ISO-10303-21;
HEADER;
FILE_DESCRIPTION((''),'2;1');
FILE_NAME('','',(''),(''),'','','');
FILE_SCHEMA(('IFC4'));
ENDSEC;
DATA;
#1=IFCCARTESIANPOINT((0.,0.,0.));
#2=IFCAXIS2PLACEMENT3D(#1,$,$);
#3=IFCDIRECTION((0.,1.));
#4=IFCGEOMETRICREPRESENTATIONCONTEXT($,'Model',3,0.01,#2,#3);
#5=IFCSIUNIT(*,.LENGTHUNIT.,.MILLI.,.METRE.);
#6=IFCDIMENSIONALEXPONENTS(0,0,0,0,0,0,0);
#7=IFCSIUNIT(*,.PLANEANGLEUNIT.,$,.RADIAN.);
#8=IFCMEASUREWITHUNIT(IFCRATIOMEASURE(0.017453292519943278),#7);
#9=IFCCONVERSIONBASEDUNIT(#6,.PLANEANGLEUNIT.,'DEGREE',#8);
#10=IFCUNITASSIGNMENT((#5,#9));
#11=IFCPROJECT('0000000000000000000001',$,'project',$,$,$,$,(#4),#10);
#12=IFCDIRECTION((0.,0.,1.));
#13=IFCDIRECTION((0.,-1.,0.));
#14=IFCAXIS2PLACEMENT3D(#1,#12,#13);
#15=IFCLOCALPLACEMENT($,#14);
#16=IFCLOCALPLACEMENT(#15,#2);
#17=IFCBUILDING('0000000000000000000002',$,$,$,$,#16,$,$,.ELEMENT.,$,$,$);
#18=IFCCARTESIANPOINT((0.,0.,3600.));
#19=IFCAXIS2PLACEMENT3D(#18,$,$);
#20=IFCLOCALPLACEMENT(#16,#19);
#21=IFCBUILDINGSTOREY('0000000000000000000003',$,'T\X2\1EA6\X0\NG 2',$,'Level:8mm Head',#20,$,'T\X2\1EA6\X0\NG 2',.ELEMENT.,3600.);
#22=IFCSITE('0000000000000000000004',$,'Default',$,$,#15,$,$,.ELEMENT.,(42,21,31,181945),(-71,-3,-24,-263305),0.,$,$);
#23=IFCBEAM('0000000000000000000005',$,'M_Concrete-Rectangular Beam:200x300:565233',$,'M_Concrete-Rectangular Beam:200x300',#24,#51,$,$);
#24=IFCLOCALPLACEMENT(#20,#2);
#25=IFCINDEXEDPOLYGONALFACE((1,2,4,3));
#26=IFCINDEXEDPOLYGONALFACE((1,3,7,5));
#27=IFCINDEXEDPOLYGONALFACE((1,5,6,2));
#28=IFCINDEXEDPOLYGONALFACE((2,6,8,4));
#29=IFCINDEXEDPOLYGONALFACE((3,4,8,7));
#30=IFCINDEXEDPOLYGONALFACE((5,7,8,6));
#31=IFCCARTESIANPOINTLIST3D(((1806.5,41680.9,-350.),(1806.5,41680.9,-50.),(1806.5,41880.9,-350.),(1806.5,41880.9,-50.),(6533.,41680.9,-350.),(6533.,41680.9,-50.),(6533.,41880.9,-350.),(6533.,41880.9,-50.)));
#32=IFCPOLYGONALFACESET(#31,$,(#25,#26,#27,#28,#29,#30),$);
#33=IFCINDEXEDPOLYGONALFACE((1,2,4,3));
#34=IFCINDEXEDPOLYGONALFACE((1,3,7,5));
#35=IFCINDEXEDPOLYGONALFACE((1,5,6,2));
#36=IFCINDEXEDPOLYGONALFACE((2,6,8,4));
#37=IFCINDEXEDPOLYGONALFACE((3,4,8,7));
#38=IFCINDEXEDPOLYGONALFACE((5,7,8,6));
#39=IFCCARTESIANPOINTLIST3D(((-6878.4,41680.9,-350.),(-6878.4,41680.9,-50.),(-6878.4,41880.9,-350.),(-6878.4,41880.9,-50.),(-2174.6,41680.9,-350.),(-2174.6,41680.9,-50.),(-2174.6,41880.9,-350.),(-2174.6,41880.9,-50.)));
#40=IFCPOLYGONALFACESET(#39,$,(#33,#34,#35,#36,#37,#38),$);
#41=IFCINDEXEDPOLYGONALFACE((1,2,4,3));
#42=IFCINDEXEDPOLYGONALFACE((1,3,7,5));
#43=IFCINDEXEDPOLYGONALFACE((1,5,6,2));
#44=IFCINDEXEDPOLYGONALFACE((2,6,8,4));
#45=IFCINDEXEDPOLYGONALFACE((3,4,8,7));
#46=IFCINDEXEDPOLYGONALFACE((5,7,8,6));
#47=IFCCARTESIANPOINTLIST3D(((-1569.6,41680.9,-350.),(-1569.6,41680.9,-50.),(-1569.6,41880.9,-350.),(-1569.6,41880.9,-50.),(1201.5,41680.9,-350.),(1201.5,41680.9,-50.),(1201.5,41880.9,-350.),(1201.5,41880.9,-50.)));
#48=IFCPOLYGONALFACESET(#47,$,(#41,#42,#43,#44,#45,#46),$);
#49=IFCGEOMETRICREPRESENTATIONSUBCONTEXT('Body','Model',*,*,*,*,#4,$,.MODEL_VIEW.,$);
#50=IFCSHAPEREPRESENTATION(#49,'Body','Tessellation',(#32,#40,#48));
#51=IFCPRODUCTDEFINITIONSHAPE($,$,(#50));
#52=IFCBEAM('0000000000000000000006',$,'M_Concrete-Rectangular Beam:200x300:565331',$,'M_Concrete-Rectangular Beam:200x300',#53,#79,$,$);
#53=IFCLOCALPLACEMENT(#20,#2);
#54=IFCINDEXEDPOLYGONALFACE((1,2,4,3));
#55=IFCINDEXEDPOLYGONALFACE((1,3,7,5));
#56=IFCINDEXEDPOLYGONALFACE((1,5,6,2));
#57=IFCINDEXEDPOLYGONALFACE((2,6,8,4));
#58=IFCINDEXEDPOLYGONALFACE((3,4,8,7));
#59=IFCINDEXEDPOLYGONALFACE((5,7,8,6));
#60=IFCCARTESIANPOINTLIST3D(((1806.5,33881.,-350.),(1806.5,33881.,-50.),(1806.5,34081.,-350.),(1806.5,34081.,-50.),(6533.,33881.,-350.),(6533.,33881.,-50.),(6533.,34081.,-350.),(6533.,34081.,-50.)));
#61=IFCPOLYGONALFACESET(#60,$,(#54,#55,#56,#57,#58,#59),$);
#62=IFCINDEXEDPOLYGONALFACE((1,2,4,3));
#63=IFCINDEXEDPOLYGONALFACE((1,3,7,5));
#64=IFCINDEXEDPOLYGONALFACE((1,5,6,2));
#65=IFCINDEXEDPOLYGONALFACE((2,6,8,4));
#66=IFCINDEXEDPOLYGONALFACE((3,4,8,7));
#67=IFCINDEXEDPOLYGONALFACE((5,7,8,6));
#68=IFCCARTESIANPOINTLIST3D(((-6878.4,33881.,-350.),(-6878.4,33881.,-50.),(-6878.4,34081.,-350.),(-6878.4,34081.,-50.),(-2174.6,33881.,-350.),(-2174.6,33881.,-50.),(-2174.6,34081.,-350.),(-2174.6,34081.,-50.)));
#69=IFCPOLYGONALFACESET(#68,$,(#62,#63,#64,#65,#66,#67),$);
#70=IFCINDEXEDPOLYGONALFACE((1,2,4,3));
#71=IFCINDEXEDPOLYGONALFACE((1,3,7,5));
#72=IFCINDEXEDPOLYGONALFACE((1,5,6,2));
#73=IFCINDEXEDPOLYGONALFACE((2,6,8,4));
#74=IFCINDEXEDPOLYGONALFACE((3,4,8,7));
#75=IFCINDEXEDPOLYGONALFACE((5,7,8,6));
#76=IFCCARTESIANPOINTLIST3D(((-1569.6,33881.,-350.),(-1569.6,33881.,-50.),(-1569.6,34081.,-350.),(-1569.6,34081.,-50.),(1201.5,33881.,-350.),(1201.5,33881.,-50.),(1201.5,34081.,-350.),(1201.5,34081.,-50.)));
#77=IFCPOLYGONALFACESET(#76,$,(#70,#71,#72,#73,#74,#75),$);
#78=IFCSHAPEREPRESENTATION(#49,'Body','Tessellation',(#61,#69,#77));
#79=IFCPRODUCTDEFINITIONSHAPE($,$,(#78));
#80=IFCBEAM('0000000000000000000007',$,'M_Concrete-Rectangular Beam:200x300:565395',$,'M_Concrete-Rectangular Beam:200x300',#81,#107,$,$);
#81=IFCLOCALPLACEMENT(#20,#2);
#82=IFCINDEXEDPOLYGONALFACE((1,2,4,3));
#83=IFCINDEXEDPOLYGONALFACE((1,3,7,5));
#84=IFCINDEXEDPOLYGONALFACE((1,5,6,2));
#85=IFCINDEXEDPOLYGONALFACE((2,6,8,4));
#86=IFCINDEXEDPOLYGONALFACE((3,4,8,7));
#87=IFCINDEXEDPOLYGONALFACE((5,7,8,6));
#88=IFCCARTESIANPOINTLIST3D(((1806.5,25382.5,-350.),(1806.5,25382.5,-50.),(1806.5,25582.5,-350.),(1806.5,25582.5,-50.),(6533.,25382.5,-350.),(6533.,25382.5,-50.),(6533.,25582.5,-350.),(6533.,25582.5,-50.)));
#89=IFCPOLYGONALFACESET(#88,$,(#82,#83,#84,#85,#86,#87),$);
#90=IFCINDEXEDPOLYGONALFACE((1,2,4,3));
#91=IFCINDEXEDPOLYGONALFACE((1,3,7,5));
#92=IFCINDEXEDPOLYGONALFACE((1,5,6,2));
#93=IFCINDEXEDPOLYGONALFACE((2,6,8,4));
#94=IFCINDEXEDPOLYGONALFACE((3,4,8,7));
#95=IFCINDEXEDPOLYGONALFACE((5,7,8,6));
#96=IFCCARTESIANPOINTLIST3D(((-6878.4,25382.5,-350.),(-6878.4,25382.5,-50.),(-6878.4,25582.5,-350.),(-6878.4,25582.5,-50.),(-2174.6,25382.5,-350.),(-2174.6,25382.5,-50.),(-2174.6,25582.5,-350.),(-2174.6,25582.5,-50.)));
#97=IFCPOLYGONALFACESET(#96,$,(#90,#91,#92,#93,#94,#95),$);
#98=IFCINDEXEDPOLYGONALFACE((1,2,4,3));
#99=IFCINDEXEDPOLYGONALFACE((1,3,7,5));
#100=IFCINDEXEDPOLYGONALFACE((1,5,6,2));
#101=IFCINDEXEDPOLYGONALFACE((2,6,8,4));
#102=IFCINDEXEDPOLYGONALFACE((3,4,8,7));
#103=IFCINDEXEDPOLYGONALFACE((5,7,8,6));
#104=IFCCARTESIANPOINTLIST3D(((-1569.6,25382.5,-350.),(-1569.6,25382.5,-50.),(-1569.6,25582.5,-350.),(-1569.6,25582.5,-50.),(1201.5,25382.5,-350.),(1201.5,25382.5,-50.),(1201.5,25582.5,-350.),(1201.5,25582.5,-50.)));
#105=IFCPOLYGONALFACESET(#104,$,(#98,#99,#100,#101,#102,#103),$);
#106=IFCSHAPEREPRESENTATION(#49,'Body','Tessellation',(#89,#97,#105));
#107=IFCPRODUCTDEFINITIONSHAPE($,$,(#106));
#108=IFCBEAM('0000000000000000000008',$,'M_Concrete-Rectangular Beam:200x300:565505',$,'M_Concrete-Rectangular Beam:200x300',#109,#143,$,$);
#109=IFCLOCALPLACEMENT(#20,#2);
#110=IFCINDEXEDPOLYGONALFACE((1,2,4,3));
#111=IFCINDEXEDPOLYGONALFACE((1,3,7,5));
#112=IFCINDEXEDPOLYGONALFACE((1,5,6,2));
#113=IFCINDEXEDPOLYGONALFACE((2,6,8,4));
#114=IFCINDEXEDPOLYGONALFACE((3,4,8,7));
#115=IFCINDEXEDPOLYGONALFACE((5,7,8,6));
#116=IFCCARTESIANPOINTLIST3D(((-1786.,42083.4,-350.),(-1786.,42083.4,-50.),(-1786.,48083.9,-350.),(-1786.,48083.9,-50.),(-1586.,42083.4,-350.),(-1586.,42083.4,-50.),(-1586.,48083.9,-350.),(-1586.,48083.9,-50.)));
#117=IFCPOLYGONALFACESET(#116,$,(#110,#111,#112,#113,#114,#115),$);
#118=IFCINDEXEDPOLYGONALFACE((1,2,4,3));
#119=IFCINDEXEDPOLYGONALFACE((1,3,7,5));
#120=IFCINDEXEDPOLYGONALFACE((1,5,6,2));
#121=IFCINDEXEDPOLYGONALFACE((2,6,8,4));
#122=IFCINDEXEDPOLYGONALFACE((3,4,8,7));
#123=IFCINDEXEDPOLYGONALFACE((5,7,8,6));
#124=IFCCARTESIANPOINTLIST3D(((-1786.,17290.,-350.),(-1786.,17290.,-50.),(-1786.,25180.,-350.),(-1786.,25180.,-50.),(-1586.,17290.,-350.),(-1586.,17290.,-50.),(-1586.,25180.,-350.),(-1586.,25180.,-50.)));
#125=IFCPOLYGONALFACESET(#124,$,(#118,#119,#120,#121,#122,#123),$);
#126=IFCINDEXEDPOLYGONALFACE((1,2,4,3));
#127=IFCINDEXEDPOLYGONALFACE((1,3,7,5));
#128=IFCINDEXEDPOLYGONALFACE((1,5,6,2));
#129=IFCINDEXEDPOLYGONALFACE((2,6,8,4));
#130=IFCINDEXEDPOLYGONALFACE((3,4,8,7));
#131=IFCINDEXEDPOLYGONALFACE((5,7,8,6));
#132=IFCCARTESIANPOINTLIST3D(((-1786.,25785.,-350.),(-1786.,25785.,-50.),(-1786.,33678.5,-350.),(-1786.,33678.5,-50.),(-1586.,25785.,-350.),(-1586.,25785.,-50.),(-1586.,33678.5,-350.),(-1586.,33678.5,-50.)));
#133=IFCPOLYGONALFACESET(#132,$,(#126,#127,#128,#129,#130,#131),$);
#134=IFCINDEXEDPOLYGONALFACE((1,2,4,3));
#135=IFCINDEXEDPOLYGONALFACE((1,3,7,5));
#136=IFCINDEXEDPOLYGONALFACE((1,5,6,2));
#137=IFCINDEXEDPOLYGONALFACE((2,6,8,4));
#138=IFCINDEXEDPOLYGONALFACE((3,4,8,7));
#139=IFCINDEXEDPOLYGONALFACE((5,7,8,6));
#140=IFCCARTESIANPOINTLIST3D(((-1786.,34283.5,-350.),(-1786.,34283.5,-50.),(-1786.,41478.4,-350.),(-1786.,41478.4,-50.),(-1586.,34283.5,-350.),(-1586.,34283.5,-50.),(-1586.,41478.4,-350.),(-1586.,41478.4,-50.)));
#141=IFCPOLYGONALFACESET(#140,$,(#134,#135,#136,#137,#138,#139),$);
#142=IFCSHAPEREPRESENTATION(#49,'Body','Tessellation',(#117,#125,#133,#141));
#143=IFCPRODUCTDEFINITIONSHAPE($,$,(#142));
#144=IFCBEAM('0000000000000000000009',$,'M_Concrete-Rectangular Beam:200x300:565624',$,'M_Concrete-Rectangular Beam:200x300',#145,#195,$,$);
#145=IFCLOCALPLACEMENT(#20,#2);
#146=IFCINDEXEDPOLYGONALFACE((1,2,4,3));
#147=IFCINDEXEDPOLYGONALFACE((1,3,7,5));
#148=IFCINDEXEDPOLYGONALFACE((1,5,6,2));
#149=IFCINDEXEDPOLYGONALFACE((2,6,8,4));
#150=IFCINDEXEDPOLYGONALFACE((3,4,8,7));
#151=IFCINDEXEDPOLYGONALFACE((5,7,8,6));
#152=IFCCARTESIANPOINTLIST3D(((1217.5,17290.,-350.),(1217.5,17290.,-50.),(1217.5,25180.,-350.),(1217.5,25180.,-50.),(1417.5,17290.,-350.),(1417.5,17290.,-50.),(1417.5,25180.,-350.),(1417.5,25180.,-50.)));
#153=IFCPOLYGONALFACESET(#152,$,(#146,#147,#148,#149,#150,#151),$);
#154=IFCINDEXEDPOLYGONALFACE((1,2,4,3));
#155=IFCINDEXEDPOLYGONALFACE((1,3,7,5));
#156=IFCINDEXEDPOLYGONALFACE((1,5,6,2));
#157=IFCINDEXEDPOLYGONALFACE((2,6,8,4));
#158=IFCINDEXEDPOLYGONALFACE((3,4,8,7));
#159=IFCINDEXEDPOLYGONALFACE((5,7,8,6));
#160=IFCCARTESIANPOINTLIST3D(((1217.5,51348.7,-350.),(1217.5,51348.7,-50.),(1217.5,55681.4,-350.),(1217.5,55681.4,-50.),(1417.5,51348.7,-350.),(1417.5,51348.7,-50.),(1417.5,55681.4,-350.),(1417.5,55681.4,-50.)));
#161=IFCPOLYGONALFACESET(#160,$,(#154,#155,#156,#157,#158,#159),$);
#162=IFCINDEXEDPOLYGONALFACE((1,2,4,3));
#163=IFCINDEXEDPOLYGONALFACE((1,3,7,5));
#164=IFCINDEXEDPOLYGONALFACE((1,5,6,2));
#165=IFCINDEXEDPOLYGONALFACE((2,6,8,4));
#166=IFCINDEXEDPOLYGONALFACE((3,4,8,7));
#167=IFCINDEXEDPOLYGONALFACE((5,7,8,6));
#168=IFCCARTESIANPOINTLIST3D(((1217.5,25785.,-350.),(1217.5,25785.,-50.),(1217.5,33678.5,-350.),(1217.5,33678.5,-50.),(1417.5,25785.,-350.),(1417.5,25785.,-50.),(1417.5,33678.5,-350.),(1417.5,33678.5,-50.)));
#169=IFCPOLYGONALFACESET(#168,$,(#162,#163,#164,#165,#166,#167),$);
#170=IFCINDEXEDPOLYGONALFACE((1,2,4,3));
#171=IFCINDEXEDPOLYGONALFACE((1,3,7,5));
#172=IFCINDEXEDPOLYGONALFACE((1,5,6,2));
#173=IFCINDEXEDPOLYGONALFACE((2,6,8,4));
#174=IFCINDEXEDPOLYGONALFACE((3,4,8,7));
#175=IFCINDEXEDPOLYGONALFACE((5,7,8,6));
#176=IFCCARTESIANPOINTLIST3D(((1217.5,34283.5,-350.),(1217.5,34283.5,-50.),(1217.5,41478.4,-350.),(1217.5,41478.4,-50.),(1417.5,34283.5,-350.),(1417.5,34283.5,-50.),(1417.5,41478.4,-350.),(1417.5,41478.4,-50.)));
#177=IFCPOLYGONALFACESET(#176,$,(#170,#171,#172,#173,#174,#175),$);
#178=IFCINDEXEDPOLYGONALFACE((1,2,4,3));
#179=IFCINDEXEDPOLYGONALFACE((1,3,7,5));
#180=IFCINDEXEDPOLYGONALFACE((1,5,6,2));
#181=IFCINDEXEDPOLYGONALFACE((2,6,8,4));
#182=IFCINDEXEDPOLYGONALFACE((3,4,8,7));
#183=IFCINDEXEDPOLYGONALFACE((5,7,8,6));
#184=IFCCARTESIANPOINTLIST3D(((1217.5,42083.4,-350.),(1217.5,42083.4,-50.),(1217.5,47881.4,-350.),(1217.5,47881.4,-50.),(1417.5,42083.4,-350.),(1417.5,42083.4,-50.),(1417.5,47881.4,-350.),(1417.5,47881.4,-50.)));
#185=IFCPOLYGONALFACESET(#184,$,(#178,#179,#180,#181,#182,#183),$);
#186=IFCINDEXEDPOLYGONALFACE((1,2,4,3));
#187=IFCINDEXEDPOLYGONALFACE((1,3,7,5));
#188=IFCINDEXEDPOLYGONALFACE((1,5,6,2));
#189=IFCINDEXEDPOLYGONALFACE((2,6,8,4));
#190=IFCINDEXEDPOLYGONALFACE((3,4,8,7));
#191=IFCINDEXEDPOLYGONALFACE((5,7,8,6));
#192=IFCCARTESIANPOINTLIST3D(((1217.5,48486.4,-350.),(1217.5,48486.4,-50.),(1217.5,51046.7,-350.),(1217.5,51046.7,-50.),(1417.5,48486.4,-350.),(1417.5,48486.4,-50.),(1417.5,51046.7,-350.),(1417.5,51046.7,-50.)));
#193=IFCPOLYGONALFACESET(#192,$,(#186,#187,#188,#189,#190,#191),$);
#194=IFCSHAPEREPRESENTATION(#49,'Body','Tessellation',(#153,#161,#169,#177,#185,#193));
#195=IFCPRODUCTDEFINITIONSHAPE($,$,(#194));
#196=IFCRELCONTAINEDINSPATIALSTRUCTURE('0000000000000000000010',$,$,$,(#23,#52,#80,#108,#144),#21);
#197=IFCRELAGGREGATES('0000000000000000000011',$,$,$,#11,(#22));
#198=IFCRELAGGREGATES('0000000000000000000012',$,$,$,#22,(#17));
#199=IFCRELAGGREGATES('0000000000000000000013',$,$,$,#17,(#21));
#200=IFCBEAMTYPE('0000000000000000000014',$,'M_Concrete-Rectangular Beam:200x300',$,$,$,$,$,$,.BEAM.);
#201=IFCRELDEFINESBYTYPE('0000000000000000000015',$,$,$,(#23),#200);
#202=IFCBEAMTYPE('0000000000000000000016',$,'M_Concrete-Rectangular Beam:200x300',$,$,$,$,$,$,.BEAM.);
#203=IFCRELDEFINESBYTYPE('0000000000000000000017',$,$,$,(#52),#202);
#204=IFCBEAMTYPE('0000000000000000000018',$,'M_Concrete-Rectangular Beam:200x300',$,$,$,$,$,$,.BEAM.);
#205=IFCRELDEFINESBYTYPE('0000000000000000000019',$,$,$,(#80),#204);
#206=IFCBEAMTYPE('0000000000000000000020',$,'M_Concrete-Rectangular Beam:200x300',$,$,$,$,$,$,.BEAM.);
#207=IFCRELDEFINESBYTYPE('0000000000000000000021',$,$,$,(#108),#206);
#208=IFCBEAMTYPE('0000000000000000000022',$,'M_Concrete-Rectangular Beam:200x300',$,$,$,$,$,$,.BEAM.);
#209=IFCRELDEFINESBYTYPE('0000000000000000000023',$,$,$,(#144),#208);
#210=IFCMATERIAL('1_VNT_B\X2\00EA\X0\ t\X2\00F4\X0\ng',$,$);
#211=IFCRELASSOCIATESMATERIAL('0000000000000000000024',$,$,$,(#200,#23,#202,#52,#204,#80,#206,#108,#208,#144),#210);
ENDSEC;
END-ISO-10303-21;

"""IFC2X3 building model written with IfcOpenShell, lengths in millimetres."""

from ifc_helpers import new_model, entity, si_unit, converted_unit, direction, frame, frame_2d, origin, origin_2d_with_axis, place, context, subcontext, project, spatial, rectangle, extrude, source, transform, mapped, material, type_object, type_shapes, element, save


model = new_model("IFC2X3")

# Units and contexts
model_context = context("Model", 3, precision=0.01, world=origin(), true_north=direction((0.0, 1.0)))
body_context = subcontext(model_context, "Body", "Model", "MODEL_VIEW")
ifc_project = project(units=[si_unit("LENGTHUNIT", "METRE", prefix="MILLI"), converted_unit("PLANEANGLEUNIT", "DEGREE", entity("IfcRatioMeasure", 0.017453292519943278), si_unit("PLANEANGLEUNIT", "RADIAN"), dimensions=[0, 0, 0, 0, 0, 0, 0])], contexts=[model_context])

# Site, building, storey
site_placement = place(None, frame((0.0, 0.0, 0.0), z_axis=(0.0, 0.0, 1.0), x_axis=(0.0, -1.0, 0.0)))
site = spatial("IfcSite", under=ifc_project, at=site_placement, Name="Default", CompositionType="ELEMENT", RefLatitude=(42, 21, 31, 181945), RefLongitude=(-71, -3, -24, -263305), RefElevation=0.0)
building_placement = place(site_placement, origin())
building = spatial("IfcBuilding", under=site, at=building_placement, CompositionType="ELEMENT")
storey_placement = place(building_placement, frame((0.0, 0.0, 3600.0)))
storey = spatial("IfcBuildingStorey", under=building, at=storey_placement, Name="TẦNG 2", ObjectType="Level:8mm Head", LongName="TẦNG 2", CompositionType="ELEMENT", Elevation=3600.0)

# Beams
ifc_material = material(Name="1_VNT_Bê tông")
beam_type_1 = type_object("IfcBeamType", Name="M_Concrete-Rectangular Beam:200x300", PredefinedType="BEAM", material=ifc_material)
shared_shape_1 = source(origin(), body_context, "Body", "SweptSolid", [
    extrude(rectangle(XDim=300.0, YDim=200.0, at=origin_2d_with_axis()), frame((1806.5, 41780.9, 3400.0), z_axis=(1.0, 0.0, 0.0), x_axis=(0.0, 0.0, -1.0)), (0.0, 0.0, 1.0), 4726.6),
    extrude(rectangle(XDim=300.0, YDim=200.0, at=origin_2d_with_axis()), frame((-6878.4, 41780.9, 3400.0), z_axis=(1.0, 0.0, 0.0), x_axis=(0.0, 0.0, -1.0)), (0.0, 0.0, 1.0), 4703.8),
    extrude(rectangle(XDim=300.0, YDim=200.0, at=origin_2d_with_axis()), frame((-1569.6, 41780.9, 3400.0), z_axis=(1.0, 0.0, 0.0), x_axis=(0.0, 0.0, -1.0)), (0.0, 0.0, 1.0), 2771.1),
])
type_shapes(beam_type_1, [shared_shape_1])
beam_1_placement = place(storey_placement, frame((0.0, 0.0, -3600.0)))
element("IfcBeam", 1, at=beam_1_placement, inside=storey, type_object=beam_type_1, material=ifc_material, Name="M_Concrete-Rectangular Beam:200x300:565233", ObjectType="M_Concrete-Rectangular Beam:200x300", context=body_context, shape_type="MappedRepresentation", body=[
    mapped(shared_shape_1, transform((0.0, 0.0, 0.0), scale=1.0)),
])
beam_type_2 = type_object("IfcBeamType", Name="M_Concrete-Rectangular Beam:200x300", PredefinedType="BEAM", material=ifc_material)
shared_shape_2 = source(origin(), body_context, "Body", "SweptSolid", [
    extrude(rectangle(XDim=300.0, YDim=200.0, at=frame_2d((0.0, 0.0), x_axis=(1.0, 0.0))), frame((1806.5, 33981.0, 3400.0), z_axis=(1.0, 0.0, 0.0), x_axis=(0.0, 0.0, -1.0)), (0.0, 0.0, 1.0), 4726.6),
    extrude(rectangle(XDim=300.0, YDim=200.0, at=origin_2d_with_axis()), frame((-6878.4, 33981.0, 3400.0), z_axis=(1.0, 0.0, 0.0), x_axis=(0.0, 0.0, -1.0)), (0.0, 0.0, 1.0), 4703.8),
    extrude(rectangle(XDim=300.0, YDim=200.0, at=frame_2d((0.0, 0.0), x_axis=(1.0, 0.0))), frame((-1569.6, 33981.0, 3400.0), z_axis=(1.0, 0.0, 0.0), x_axis=(0.0, 0.0, -1.0)), (0.0, 0.0, 1.0), 2771.1),
])
type_shapes(beam_type_2, [shared_shape_2])
beam_2_placement = place(storey_placement, frame((0.0, 0.0, -3600.0)))
element("IfcBeam", 2, at=beam_2_placement, inside=storey, type_object=beam_type_2, material=ifc_material, Name="M_Concrete-Rectangular Beam:200x300:565331", ObjectType="M_Concrete-Rectangular Beam:200x300", context=body_context, shape_type="MappedRepresentation", body=[
    mapped(shared_shape_2, transform((0.0, 0.0, 0.0), scale=1.0)),
])
beam_type_3 = type_object("IfcBeamType", Name="M_Concrete-Rectangular Beam:200x300", PredefinedType="BEAM", material=ifc_material)
shared_shape_3 = source(origin(), body_context, "Body", "SweptSolid", [
    extrude(rectangle(XDim=300.0, YDim=200.0, at=frame_2d((0.0, 0.0), x_axis=(1.0, 0.0))), frame((1806.5, 25482.5, 3400.0), z_axis=(1.0, 0.0, 0.0), x_axis=(0.0, 0.0, -1.0)), (0.0, 0.0, 1.0), 4726.6),
    extrude(rectangle(XDim=300.0, YDim=200.0, at=frame_2d((0.0, 0.0), x_axis=(1.0, 0.0))), frame((-6878.4, 25482.5, 3400.0), z_axis=(1.0, 0.0, 0.0), x_axis=(0.0, 0.0, -1.0)), (0.0, 0.0, 1.0), 4703.8),
    extrude(rectangle(XDim=300.0, YDim=200.0, at=frame_2d((0.0, 0.0), x_axis=(1.0, 0.0))), frame((-1569.6, 25482.5, 3400.0), z_axis=(1.0, 0.0, 0.0), x_axis=(0.0, 0.0, -1.0)), (0.0, 0.0, 1.0), 2771.1),
])
type_shapes(beam_type_3, [shared_shape_3])
beam_3_placement = place(storey_placement, frame((0.0, 0.0, -3600.0)))
element("IfcBeam", 3, at=beam_3_placement, inside=storey, type_object=beam_type_3, material=ifc_material, Name="M_Concrete-Rectangular Beam:200x300:565395", ObjectType="M_Concrete-Rectangular Beam:200x300", context=body_context, shape_type="MappedRepresentation", body=[
    mapped(shared_shape_3, transform((0.0, 0.0, 0.0), scale=1.0)),
])
beam_type_4 = type_object("IfcBeamType", Name="M_Concrete-Rectangular Beam:200x300", PredefinedType="BEAM", material=ifc_material)
shared_shape_4 = source(origin(), body_context, "Body", "SweptSolid", [
    extrude(rectangle(XDim=300.0, YDim=200.0, at=frame_2d((0.0, 0.0), x_axis=(0.0, 1.0))), frame((-1686.0, 42083.4, 3400.0), z_axis=(0.0, 1.0, 0.0), x_axis=(-1.0, 0.0, 0.0)), (0.0, 0.0, 1.0), 6000.5),
    extrude(rectangle(XDim=300.0, YDim=200.0, at=frame_2d((0.0, 0.0), x_axis=(0.0, 1.0))), frame((-1686.0, 17290.0, 3400.0), z_axis=(0.0, 1.0, 0.0), x_axis=(-1.0, 0.0, 0.0)), (0.0, 0.0, 1.0), 7890.0),
    extrude(rectangle(XDim=300.0, YDim=200.0, at=frame_2d((0.0, 0.0), x_axis=(0.0, 1.0))), frame((-1686.0, 25785.0, 3400.0), z_axis=(0.0, 1.0, 0.0), x_axis=(-1.0, 0.0, 0.0)), (0.0, 0.0, 1.0), 7893.5),
    extrude(rectangle(XDim=300.0, YDim=200.0, at=frame_2d((0.0, 0.0), x_axis=(0.0, 1.0))), frame((-1686.0, 34283.5, 3400.0), z_axis=(0.0, 1.0, 0.0), x_axis=(-1.0, 0.0, 0.0)), (0.0, 0.0, 1.0), 7195.0),
])
type_shapes(beam_type_4, [shared_shape_4])
beam_4_placement = place(storey_placement, frame((0.0, 0.0, -3600.0)))
element("IfcBeam", 4, at=beam_4_placement, inside=storey, type_object=beam_type_4, material=ifc_material, Name="M_Concrete-Rectangular Beam:200x300:565505", ObjectType="M_Concrete-Rectangular Beam:200x300", context=body_context, shape_type="MappedRepresentation", body=[
    mapped(shared_shape_4, transform((0.0, 0.0, 0.0), scale=1.0)),
])
beam_type_5 = type_object("IfcBeamType", Name="M_Concrete-Rectangular Beam:200x300", PredefinedType="BEAM", material=ifc_material)
shared_shape_5 = source(origin(), body_context, "Body", "SweptSolid", [
    extrude(rectangle(XDim=300.0, YDim=200.0, at=frame_2d((0.0, 0.0), x_axis=(0.0, 1.0))), frame((1317.5, 25180.0, 3400.0), z_axis=(0.0, -1.0, 0.0), x_axis=(-1.0, 0.0, 0.0)), (0.0, 0.0, 1.0), 7890.0),
    extrude(rectangle(XDim=300.0, YDim=200.0, at=frame_2d((0.0, 0.0), x_axis=(0.0, 1.0))), frame((1317.5, 55681.4, 3400.0), z_axis=(0.0, -1.0, 0.0), x_axis=(-1.0, 0.0, 0.0)), (0.0, 0.0, 1.0), 4332.7),
    extrude(rectangle(XDim=300.0, YDim=200.0, at=frame_2d((0.0, 0.0), x_axis=(0.0, 1.0))), frame((1317.5, 33678.5, 3400.0), z_axis=(0.0, -1.0, 0.0), x_axis=(-1.0, 0.0, 0.0)), (0.0, 0.0, 1.0), 7893.5),
    extrude(rectangle(XDim=300.0, YDim=200.0, at=frame_2d((0.0, 0.0), x_axis=(0.0, 1.0))), frame((1317.5, 41478.4, 3400.0), z_axis=(0.0, -1.0, 0.0), x_axis=(-1.0, 0.0, 0.0)), (0.0, 0.0, 1.0), 7195.0),
    extrude(rectangle(XDim=300.0, YDim=200.0, at=frame_2d((0.0, 0.0), x_axis=(0.0, 1.0))), frame((1317.5, 47881.4, 3400.0), z_axis=(0.0, -1.0, 0.0), x_axis=(-1.0, 0.0, 0.0)), (0.0, 0.0, 1.0), 5798.0),
    extrude(rectangle(XDim=300.0, YDim=200.0, at=frame_2d((0.0, 0.0), x_axis=(0.0, 1.0))), frame((1317.5, 51046.7, 3400.0), z_axis=(0.0, -1.0, 0.0), x_axis=(-1.0, 0.0, 0.0)), (0.0, 0.0, 1.0), 2560.3),
])
type_shapes(beam_type_5, [shared_shape_5])
beam_5_placement = place(storey_placement, frame((0.0, 0.0, -3600.0)))
element("IfcBeam", 5, at=beam_5_placement, inside=storey, type_object=beam_type_5, material=ifc_material, Name="M_Concrete-Rectangular Beam:200x300:565624", ObjectType="M_Concrete-Rectangular Beam:200x300", context=body_context, shape_type="MappedRepresentation", body=[
    mapped(shared_shape_5, transform((0.0, 0.0, 0.0), scale=1.0)),
])

save(model, "model.ifc")
